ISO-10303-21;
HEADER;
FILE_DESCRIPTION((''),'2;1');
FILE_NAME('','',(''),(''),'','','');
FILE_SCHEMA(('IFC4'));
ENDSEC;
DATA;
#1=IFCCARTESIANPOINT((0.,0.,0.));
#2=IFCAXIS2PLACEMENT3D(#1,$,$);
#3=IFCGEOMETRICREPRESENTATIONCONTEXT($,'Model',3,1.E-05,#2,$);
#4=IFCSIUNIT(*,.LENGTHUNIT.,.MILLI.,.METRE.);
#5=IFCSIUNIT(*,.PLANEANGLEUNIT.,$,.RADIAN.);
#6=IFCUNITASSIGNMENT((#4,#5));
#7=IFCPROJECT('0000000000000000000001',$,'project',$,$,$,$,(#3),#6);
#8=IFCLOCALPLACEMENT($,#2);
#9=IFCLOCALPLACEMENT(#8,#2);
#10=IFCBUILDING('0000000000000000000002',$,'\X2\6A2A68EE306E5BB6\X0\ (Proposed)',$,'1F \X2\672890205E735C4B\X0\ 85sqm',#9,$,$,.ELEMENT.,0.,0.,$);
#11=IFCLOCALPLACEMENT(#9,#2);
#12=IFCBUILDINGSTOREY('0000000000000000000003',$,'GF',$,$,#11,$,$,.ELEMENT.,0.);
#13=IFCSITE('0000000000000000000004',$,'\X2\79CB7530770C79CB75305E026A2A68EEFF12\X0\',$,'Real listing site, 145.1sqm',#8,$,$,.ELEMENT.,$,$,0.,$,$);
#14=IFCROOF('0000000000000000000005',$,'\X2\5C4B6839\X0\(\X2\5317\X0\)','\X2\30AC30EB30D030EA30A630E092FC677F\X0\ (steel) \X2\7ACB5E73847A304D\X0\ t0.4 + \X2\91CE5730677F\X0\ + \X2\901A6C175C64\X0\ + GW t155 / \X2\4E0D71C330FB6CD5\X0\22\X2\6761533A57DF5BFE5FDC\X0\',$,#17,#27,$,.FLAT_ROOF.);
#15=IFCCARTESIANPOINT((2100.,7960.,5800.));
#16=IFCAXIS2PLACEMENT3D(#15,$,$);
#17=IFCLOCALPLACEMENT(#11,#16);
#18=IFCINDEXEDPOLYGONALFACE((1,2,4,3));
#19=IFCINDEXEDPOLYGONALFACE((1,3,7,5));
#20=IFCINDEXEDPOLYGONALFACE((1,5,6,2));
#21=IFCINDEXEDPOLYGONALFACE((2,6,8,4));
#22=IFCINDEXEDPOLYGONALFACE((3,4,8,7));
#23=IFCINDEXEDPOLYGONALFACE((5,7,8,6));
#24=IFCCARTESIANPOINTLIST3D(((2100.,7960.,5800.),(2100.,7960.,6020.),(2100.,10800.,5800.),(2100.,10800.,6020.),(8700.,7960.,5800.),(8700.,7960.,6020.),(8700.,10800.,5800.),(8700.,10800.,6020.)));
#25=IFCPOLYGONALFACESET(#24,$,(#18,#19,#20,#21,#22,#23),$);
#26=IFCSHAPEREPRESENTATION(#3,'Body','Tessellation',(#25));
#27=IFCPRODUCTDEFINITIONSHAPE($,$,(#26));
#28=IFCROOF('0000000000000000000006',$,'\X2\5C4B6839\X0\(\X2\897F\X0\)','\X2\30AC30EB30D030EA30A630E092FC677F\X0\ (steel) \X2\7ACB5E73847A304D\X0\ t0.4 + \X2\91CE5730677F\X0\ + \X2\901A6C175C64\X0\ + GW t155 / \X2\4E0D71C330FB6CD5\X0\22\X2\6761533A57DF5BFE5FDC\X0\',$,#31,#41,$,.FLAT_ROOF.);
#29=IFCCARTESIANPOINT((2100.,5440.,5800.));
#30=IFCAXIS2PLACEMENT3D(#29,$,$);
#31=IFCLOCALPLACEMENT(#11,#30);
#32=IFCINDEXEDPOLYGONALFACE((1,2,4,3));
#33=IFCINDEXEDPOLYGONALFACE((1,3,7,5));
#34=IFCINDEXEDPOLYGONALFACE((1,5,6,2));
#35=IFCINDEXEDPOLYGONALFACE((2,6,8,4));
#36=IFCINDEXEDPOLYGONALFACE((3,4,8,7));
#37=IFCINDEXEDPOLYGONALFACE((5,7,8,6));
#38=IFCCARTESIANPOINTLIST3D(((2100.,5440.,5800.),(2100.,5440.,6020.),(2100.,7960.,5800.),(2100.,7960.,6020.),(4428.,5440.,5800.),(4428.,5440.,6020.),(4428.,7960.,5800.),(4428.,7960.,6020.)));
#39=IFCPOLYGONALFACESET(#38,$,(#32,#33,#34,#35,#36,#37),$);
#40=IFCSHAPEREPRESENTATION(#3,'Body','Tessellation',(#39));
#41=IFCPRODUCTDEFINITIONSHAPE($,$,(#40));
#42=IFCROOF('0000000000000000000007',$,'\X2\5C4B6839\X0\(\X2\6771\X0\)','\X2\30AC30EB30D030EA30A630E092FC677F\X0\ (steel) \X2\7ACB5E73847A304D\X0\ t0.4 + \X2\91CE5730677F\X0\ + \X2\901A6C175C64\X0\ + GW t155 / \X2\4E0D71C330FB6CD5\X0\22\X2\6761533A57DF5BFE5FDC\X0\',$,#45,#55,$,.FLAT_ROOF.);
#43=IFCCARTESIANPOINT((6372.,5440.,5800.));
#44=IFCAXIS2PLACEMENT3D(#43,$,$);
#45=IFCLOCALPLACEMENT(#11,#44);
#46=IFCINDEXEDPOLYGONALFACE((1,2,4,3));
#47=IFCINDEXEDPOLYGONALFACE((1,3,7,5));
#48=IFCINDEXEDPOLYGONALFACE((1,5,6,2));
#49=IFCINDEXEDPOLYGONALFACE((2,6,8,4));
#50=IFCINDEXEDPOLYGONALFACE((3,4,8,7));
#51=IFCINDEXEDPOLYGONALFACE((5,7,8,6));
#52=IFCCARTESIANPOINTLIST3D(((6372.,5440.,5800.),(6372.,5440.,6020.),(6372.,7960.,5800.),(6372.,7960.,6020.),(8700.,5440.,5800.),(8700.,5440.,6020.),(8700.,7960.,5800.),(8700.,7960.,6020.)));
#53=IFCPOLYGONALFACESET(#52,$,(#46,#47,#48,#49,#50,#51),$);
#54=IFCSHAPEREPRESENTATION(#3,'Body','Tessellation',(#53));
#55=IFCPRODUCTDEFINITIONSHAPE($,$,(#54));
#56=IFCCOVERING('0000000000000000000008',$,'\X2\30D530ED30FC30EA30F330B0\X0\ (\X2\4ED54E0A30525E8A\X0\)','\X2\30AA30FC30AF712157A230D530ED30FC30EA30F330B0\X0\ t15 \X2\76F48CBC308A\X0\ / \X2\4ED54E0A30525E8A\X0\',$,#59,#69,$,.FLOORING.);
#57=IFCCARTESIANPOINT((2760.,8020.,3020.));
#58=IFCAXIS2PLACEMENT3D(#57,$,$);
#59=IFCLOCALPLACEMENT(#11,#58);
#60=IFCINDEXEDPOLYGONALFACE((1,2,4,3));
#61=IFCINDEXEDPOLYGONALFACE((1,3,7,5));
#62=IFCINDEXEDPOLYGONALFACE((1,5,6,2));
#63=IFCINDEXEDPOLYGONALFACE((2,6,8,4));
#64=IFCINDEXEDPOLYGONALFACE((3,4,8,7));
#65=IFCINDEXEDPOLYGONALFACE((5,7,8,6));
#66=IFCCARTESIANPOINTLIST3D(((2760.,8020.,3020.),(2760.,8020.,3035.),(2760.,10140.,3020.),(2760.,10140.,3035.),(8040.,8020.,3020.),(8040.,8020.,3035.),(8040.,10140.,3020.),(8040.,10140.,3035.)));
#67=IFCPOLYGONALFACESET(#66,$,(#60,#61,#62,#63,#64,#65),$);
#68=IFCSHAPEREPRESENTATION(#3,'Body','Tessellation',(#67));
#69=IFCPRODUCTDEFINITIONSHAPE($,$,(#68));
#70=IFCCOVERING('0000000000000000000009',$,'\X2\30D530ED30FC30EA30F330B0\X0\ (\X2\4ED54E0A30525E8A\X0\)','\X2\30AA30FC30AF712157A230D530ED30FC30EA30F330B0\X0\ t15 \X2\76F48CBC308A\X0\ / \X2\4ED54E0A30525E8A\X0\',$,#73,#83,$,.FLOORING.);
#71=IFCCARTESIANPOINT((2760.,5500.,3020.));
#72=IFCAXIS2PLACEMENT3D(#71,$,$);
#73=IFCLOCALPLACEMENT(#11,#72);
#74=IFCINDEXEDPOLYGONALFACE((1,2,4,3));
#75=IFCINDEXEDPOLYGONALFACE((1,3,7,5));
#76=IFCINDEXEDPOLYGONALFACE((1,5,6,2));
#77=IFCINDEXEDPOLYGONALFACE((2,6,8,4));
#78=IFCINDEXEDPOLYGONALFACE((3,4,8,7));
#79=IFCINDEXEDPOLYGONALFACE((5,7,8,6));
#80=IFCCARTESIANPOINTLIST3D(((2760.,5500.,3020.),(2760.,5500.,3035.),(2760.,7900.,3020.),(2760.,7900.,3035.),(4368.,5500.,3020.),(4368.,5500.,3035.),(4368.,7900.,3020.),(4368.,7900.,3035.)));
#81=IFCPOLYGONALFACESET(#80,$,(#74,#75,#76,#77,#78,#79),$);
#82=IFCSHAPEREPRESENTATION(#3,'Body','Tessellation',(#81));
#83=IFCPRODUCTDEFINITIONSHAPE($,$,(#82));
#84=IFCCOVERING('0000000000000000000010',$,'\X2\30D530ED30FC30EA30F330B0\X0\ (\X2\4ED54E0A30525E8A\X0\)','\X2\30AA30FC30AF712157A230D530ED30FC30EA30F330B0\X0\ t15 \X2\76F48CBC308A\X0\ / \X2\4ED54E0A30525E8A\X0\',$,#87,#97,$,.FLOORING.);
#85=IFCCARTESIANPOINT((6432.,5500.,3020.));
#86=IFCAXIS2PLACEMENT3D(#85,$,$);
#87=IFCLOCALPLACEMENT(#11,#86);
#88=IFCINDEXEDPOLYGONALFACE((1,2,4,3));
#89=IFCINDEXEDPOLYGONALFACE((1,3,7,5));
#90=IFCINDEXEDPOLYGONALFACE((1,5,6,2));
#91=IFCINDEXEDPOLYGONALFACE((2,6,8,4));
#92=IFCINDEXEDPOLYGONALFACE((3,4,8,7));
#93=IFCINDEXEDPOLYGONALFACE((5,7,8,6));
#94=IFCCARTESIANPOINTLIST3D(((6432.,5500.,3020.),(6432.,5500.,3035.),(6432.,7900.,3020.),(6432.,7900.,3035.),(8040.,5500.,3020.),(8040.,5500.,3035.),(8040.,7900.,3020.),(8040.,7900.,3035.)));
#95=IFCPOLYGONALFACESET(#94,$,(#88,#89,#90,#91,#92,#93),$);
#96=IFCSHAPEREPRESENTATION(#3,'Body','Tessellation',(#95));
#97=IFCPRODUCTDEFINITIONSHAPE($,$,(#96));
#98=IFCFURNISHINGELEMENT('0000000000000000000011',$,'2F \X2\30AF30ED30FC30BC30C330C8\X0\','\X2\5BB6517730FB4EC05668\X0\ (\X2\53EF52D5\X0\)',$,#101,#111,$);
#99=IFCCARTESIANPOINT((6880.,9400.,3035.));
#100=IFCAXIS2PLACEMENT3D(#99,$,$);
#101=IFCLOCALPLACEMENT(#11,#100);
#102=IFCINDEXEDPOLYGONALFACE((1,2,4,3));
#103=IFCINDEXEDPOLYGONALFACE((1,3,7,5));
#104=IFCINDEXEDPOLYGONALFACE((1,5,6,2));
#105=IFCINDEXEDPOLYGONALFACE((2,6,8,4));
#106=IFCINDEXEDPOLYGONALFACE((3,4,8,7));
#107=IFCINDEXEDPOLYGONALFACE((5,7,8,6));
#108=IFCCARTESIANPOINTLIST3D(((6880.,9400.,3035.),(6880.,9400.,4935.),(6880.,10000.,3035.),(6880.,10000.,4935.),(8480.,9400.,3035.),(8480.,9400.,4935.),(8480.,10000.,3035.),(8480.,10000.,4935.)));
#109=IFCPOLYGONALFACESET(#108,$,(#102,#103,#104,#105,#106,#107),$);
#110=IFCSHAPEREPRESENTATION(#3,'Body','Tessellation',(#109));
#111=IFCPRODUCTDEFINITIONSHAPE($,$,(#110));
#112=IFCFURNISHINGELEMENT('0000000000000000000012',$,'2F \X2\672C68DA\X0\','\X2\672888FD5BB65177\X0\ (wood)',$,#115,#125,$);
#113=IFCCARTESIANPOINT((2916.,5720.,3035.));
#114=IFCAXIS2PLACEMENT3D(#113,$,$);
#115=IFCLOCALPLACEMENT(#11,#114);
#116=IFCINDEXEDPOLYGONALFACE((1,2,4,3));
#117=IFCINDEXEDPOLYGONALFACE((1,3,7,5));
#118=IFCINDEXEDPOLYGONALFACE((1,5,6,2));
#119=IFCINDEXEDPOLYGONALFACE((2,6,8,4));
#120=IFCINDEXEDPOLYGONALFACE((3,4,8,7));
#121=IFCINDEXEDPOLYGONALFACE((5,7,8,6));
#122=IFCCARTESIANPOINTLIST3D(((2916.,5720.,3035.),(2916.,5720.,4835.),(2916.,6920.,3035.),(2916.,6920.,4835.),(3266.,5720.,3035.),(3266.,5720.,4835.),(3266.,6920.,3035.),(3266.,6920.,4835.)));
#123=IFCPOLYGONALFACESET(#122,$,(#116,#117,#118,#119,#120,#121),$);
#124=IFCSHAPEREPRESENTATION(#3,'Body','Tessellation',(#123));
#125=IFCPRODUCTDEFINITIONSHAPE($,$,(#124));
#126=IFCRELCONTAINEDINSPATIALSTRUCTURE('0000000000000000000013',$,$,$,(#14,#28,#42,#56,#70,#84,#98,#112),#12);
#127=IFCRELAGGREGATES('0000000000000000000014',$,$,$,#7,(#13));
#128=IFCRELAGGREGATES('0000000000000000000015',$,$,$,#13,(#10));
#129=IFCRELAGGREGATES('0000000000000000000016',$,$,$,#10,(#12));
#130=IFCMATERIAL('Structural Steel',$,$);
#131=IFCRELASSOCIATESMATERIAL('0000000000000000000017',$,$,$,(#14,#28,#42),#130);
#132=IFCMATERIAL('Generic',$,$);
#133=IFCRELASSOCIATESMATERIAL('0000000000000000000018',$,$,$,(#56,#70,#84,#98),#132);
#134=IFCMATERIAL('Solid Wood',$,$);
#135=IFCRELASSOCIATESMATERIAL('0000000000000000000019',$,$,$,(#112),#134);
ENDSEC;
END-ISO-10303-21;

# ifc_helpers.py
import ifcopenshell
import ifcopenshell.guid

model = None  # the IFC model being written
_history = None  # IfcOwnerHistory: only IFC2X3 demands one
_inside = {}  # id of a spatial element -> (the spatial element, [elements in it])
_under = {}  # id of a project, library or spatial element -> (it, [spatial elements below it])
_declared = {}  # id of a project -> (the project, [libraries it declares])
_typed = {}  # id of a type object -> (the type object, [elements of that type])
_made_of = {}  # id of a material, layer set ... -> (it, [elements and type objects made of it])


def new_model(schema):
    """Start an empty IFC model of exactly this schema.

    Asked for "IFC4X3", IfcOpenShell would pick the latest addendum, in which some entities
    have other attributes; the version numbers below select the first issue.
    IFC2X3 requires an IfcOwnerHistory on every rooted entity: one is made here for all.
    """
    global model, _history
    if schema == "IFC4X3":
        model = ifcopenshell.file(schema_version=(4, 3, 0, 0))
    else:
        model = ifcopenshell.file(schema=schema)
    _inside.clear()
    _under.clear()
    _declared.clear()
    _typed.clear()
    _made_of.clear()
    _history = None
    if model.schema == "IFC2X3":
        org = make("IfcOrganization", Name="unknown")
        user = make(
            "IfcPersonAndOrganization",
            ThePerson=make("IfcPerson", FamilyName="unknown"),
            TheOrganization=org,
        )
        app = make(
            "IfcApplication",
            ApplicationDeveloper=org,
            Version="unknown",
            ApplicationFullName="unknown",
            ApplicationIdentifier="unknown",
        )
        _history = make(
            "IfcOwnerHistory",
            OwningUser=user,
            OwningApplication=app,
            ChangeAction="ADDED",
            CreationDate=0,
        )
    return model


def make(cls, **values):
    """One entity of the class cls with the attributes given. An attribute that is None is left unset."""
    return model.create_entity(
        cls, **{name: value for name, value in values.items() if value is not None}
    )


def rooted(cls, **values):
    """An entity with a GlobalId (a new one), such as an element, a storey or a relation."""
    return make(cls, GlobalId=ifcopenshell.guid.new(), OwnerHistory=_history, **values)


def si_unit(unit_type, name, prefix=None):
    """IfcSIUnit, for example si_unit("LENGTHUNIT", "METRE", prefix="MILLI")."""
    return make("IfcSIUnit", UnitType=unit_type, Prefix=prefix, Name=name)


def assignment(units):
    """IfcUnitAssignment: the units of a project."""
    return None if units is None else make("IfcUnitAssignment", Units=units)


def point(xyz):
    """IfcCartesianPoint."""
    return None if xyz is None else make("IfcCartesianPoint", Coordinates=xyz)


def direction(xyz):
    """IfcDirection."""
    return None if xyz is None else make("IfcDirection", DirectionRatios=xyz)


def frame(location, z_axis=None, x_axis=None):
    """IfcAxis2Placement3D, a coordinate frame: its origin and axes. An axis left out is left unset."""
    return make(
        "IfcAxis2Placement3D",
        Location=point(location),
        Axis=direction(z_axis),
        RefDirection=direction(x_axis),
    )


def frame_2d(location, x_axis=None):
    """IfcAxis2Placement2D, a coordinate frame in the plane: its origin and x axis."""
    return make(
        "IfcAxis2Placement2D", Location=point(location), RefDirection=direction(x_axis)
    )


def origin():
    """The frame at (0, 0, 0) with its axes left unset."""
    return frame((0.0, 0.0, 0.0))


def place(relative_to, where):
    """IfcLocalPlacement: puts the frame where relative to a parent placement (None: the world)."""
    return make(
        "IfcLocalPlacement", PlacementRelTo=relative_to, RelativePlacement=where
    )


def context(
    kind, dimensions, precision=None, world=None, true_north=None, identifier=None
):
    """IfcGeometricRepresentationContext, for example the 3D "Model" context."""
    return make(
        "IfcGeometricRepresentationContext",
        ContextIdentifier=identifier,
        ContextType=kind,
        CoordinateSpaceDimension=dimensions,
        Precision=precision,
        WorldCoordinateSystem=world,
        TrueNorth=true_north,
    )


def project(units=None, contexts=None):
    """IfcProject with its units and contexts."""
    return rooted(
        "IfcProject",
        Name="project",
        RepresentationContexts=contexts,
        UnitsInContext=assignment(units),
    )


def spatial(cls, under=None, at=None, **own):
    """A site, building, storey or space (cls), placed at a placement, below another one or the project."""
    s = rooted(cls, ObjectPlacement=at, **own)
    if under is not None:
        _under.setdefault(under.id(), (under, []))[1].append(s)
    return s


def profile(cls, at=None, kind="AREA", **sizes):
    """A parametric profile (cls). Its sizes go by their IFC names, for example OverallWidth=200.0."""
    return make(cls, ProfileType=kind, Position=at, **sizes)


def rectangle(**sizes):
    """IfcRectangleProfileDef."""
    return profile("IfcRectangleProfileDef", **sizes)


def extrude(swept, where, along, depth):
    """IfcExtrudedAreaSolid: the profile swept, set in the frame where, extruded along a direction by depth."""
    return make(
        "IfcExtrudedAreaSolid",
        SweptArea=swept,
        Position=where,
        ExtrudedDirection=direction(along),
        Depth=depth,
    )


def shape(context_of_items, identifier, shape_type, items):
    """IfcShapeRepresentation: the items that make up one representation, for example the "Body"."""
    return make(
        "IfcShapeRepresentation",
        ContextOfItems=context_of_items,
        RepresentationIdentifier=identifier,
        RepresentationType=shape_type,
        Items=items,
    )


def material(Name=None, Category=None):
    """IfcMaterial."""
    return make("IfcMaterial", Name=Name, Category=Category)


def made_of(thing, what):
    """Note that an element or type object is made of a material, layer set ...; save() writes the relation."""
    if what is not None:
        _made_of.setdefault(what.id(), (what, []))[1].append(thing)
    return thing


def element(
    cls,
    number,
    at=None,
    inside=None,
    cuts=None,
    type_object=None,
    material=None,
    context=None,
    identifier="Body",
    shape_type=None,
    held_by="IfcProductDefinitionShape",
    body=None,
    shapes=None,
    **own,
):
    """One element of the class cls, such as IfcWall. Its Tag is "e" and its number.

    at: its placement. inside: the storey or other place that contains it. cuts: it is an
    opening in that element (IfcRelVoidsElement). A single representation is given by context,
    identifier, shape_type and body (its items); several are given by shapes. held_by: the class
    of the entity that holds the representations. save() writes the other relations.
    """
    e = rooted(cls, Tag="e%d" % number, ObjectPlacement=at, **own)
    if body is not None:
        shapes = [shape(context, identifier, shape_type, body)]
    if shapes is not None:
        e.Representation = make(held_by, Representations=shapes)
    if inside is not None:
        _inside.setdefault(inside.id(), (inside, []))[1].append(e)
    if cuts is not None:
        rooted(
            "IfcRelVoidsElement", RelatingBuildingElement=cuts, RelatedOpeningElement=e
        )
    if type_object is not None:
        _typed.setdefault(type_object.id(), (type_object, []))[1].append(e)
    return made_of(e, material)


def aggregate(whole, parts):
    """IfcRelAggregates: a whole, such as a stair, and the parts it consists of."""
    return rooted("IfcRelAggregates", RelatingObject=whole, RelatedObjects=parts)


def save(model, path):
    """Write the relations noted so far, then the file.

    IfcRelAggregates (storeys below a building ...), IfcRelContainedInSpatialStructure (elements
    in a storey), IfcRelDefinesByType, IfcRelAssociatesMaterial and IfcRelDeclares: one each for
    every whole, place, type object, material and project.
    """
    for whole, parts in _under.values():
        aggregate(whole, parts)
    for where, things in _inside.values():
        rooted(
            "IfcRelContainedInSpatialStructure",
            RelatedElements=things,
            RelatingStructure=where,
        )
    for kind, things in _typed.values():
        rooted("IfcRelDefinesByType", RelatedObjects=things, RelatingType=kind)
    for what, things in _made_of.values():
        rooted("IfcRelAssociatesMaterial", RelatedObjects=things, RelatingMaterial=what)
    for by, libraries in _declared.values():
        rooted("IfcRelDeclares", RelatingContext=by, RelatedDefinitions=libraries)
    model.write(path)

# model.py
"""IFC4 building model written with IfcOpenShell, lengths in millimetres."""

from ifc_helpers import new_model, si_unit, frame, frame_2d, origin, place, context, project, spatial, rectangle, extrude, material, element, save


model = new_model("IFC4")

# Units and contexts
model_context = context("Model", 3, precision=1e-05, world=origin())
ifc_project = project(units=[si_unit("LENGTHUNIT", "METRE", prefix="MILLI"), si_unit("PLANEANGLEUNIT", "RADIAN")], contexts=[model_context])

# Site, building, storey
site_placement = place(None, origin())
site = spatial("IfcSite", under=ifc_project, at=site_placement, Name="秋田県秋田市横森２", ObjectType="Real listing site, 145.1sqm", CompositionType="ELEMENT", RefElevation=0.0)
building_placement = place(site_placement, origin())
building = spatial("IfcBuilding", under=site, at=building_placement, Name="横森の家 (Proposed)", ObjectType="1F 木造平屋 85sqm", CompositionType="ELEMENT", ElevationOfRefHeight=0.0, ElevationOfTerrain=0.0)
storey_placement = place(building_placement, origin())
storey = spatial("IfcBuildingStorey", under=building, at=storey_placement, Name="GF", CompositionType="ELEMENT", Elevation=0.0)

# Shared definitions
ifc_material_1 = material(Name="Solid Wood")

# Roofs
ifc_material_2 = material(Name="Structural Steel")
for number, where, name in (
    (1, (2100.0, 7960.0, 5800.0), "屋根(北)"),
):
    element("IfcRoof", number, at=place(storey_placement, frame(where)), inside=storey, material=ifc_material_2, Name=name, Description="ガルバリウム鋼板 (steel) 立平葺き t0.4 + 野地板 + 通気層 + GW t155 / 不燃・法22条区域対応", PredefinedType="FLAT_ROOF", context=model_context, shape_type="SweptSolid", body=[
        extrude(rectangle(XDim=6600.0, YDim=2840.0, at=frame_2d((3300.0, 1420.0))), frame((2100.0, 7960.0, 5800.0)), (0.0, 0.0, 1.0), 220.0),
    ])
roof_1_placement = place(storey_placement, frame((2100.0, 5440.0, 5800.0)))
element("IfcRoof", 2, at=roof_1_placement, inside=storey, material=ifc_material_2, Name="屋根(西)", Description="ガルバリウム鋼板 (steel) 立平葺き t0.4 + 野地板 + 通気層 + GW t155 / 不燃・法22条区域対応", PredefinedType="FLAT_ROOF", context=model_context, shape_type="SweptSolid", body=[
    extrude(rectangle(XDim=2328.0, YDim=2520.0, at=frame_2d((1164.0, 1260.0))), frame((2100.0, 5440.0, 5800.0)), (0.0, 0.0, 1.0), 220.0),
])
roof_2_placement = place(storey_placement, frame((6372.0, 5440.0, 5800.0)))
element("IfcRoof", 3, at=roof_2_placement, inside=storey, material=ifc_material_2, Name="屋根(東)", Description="ガルバリウム鋼板 (steel) 立平葺き t0.4 + 野地板 + 通気層 + GW t155 / 不燃・法22条区域対応", PredefinedType="FLAT_ROOF", context=model_context, shape_type="SweptSolid", body=[
    extrude(rectangle(XDim=2328.0, YDim=2520.0, at=frame_2d((1164.0, 1260.0))), frame((6372.0, 5440.0, 5800.0)), (0.0, 0.0, 1.0), 220.0),
])

# Coverings
ifc_material_3 = material(Name="Generic")
covering_1_placement = place(storey_placement, frame((2760.0, 8020.0, 3020.0)))
element("IfcCovering", 4, at=covering_1_placement, inside=storey, material=ifc_material_3, Name="フローリング (仕上げ床)", Description="オーク無垢フローリング t15 直貼り / 仕上げ床", PredefinedType="FLOORING", context=model_context, shape_type="SweptSolid", body=[
    extrude(rectangle(XDim=5280.0, YDim=2120.0, at=frame_2d((2640.0, 1060.0))), frame((2760.0, 8020.0, 3020.0)), (0.0, 0.0, 1.0), 15.0),
])
covering_2_placement = place(storey_placement, frame((2760.0, 5500.0, 3020.0)))
element("IfcCovering", 5, at=covering_2_placement, inside=storey, material=ifc_material_3, Name="フローリング (仕上げ床)", Description="オーク無垢フローリング t15 直貼り / 仕上げ床", PredefinedType="FLOORING", context=model_context, shape_type="SweptSolid", body=[
    extrude(rectangle(XDim=1608.0, YDim=2400.0, at=frame_2d((804.0, 1200.0))), frame((2760.0, 5500.0, 3020.0)), (0.0, 0.0, 1.0), 15.0),
])
covering_3_placement = place(storey_placement, frame((6432.0, 5500.0, 3020.0)))
element("IfcCovering", 6, at=covering_3_placement, inside=storey, material=ifc_material_3, Name="フローリング (仕上げ床)", Description="オーク無垢フローリング t15 直貼り / 仕上げ床", PredefinedType="FLOORING", context=model_context, shape_type="SweptSolid", body=[
    extrude(rectangle(XDim=1608.0, YDim=2400.0, at=frame_2d((804.0, 1200.0))), frame((6432.0, 5500.0, 3020.0)), (0.0, 0.0, 1.0), 15.0),
])

# Furnishing elements
furnishing_1_placement = place(storey_placement, frame((6880.0, 9400.0, 3035.0)))
element("IfcFurnishingElement", 7, at=furnishing_1_placement, inside=storey, material=ifc_material_3, Name="2F クローゼット", Description="家具・什器 (可動)", context=model_context, shape_type="SweptSolid", body=[
    extrude(rectangle(XDim=1600.0, YDim=600.0, at=frame_2d((800.0, 300.0))), frame((6880.0, 9400.0, 3035.0)), (0.0, 0.0, 1.0), 1900.0),
])
furnishing_2_placement = place(storey_placement, frame((2916.0, 5720.0, 3035.0)))
element("IfcFurnishingElement", 8, at=furnishing_2_placement, inside=storey, material=ifc_material_1, Name="2F 本棚", Description="木製家具 (wood)", context=model_context, shape_type="SweptSolid", body=[
    extrude(rectangle(XDim=350.0, YDim=1200.0, at=frame_2d((175.0, 600.0))), frame((2916.0, 5720.0, 3035.0)), (0.0, 0.0, 1.0), 1800.0),
])

save(model, "model.ifc")
